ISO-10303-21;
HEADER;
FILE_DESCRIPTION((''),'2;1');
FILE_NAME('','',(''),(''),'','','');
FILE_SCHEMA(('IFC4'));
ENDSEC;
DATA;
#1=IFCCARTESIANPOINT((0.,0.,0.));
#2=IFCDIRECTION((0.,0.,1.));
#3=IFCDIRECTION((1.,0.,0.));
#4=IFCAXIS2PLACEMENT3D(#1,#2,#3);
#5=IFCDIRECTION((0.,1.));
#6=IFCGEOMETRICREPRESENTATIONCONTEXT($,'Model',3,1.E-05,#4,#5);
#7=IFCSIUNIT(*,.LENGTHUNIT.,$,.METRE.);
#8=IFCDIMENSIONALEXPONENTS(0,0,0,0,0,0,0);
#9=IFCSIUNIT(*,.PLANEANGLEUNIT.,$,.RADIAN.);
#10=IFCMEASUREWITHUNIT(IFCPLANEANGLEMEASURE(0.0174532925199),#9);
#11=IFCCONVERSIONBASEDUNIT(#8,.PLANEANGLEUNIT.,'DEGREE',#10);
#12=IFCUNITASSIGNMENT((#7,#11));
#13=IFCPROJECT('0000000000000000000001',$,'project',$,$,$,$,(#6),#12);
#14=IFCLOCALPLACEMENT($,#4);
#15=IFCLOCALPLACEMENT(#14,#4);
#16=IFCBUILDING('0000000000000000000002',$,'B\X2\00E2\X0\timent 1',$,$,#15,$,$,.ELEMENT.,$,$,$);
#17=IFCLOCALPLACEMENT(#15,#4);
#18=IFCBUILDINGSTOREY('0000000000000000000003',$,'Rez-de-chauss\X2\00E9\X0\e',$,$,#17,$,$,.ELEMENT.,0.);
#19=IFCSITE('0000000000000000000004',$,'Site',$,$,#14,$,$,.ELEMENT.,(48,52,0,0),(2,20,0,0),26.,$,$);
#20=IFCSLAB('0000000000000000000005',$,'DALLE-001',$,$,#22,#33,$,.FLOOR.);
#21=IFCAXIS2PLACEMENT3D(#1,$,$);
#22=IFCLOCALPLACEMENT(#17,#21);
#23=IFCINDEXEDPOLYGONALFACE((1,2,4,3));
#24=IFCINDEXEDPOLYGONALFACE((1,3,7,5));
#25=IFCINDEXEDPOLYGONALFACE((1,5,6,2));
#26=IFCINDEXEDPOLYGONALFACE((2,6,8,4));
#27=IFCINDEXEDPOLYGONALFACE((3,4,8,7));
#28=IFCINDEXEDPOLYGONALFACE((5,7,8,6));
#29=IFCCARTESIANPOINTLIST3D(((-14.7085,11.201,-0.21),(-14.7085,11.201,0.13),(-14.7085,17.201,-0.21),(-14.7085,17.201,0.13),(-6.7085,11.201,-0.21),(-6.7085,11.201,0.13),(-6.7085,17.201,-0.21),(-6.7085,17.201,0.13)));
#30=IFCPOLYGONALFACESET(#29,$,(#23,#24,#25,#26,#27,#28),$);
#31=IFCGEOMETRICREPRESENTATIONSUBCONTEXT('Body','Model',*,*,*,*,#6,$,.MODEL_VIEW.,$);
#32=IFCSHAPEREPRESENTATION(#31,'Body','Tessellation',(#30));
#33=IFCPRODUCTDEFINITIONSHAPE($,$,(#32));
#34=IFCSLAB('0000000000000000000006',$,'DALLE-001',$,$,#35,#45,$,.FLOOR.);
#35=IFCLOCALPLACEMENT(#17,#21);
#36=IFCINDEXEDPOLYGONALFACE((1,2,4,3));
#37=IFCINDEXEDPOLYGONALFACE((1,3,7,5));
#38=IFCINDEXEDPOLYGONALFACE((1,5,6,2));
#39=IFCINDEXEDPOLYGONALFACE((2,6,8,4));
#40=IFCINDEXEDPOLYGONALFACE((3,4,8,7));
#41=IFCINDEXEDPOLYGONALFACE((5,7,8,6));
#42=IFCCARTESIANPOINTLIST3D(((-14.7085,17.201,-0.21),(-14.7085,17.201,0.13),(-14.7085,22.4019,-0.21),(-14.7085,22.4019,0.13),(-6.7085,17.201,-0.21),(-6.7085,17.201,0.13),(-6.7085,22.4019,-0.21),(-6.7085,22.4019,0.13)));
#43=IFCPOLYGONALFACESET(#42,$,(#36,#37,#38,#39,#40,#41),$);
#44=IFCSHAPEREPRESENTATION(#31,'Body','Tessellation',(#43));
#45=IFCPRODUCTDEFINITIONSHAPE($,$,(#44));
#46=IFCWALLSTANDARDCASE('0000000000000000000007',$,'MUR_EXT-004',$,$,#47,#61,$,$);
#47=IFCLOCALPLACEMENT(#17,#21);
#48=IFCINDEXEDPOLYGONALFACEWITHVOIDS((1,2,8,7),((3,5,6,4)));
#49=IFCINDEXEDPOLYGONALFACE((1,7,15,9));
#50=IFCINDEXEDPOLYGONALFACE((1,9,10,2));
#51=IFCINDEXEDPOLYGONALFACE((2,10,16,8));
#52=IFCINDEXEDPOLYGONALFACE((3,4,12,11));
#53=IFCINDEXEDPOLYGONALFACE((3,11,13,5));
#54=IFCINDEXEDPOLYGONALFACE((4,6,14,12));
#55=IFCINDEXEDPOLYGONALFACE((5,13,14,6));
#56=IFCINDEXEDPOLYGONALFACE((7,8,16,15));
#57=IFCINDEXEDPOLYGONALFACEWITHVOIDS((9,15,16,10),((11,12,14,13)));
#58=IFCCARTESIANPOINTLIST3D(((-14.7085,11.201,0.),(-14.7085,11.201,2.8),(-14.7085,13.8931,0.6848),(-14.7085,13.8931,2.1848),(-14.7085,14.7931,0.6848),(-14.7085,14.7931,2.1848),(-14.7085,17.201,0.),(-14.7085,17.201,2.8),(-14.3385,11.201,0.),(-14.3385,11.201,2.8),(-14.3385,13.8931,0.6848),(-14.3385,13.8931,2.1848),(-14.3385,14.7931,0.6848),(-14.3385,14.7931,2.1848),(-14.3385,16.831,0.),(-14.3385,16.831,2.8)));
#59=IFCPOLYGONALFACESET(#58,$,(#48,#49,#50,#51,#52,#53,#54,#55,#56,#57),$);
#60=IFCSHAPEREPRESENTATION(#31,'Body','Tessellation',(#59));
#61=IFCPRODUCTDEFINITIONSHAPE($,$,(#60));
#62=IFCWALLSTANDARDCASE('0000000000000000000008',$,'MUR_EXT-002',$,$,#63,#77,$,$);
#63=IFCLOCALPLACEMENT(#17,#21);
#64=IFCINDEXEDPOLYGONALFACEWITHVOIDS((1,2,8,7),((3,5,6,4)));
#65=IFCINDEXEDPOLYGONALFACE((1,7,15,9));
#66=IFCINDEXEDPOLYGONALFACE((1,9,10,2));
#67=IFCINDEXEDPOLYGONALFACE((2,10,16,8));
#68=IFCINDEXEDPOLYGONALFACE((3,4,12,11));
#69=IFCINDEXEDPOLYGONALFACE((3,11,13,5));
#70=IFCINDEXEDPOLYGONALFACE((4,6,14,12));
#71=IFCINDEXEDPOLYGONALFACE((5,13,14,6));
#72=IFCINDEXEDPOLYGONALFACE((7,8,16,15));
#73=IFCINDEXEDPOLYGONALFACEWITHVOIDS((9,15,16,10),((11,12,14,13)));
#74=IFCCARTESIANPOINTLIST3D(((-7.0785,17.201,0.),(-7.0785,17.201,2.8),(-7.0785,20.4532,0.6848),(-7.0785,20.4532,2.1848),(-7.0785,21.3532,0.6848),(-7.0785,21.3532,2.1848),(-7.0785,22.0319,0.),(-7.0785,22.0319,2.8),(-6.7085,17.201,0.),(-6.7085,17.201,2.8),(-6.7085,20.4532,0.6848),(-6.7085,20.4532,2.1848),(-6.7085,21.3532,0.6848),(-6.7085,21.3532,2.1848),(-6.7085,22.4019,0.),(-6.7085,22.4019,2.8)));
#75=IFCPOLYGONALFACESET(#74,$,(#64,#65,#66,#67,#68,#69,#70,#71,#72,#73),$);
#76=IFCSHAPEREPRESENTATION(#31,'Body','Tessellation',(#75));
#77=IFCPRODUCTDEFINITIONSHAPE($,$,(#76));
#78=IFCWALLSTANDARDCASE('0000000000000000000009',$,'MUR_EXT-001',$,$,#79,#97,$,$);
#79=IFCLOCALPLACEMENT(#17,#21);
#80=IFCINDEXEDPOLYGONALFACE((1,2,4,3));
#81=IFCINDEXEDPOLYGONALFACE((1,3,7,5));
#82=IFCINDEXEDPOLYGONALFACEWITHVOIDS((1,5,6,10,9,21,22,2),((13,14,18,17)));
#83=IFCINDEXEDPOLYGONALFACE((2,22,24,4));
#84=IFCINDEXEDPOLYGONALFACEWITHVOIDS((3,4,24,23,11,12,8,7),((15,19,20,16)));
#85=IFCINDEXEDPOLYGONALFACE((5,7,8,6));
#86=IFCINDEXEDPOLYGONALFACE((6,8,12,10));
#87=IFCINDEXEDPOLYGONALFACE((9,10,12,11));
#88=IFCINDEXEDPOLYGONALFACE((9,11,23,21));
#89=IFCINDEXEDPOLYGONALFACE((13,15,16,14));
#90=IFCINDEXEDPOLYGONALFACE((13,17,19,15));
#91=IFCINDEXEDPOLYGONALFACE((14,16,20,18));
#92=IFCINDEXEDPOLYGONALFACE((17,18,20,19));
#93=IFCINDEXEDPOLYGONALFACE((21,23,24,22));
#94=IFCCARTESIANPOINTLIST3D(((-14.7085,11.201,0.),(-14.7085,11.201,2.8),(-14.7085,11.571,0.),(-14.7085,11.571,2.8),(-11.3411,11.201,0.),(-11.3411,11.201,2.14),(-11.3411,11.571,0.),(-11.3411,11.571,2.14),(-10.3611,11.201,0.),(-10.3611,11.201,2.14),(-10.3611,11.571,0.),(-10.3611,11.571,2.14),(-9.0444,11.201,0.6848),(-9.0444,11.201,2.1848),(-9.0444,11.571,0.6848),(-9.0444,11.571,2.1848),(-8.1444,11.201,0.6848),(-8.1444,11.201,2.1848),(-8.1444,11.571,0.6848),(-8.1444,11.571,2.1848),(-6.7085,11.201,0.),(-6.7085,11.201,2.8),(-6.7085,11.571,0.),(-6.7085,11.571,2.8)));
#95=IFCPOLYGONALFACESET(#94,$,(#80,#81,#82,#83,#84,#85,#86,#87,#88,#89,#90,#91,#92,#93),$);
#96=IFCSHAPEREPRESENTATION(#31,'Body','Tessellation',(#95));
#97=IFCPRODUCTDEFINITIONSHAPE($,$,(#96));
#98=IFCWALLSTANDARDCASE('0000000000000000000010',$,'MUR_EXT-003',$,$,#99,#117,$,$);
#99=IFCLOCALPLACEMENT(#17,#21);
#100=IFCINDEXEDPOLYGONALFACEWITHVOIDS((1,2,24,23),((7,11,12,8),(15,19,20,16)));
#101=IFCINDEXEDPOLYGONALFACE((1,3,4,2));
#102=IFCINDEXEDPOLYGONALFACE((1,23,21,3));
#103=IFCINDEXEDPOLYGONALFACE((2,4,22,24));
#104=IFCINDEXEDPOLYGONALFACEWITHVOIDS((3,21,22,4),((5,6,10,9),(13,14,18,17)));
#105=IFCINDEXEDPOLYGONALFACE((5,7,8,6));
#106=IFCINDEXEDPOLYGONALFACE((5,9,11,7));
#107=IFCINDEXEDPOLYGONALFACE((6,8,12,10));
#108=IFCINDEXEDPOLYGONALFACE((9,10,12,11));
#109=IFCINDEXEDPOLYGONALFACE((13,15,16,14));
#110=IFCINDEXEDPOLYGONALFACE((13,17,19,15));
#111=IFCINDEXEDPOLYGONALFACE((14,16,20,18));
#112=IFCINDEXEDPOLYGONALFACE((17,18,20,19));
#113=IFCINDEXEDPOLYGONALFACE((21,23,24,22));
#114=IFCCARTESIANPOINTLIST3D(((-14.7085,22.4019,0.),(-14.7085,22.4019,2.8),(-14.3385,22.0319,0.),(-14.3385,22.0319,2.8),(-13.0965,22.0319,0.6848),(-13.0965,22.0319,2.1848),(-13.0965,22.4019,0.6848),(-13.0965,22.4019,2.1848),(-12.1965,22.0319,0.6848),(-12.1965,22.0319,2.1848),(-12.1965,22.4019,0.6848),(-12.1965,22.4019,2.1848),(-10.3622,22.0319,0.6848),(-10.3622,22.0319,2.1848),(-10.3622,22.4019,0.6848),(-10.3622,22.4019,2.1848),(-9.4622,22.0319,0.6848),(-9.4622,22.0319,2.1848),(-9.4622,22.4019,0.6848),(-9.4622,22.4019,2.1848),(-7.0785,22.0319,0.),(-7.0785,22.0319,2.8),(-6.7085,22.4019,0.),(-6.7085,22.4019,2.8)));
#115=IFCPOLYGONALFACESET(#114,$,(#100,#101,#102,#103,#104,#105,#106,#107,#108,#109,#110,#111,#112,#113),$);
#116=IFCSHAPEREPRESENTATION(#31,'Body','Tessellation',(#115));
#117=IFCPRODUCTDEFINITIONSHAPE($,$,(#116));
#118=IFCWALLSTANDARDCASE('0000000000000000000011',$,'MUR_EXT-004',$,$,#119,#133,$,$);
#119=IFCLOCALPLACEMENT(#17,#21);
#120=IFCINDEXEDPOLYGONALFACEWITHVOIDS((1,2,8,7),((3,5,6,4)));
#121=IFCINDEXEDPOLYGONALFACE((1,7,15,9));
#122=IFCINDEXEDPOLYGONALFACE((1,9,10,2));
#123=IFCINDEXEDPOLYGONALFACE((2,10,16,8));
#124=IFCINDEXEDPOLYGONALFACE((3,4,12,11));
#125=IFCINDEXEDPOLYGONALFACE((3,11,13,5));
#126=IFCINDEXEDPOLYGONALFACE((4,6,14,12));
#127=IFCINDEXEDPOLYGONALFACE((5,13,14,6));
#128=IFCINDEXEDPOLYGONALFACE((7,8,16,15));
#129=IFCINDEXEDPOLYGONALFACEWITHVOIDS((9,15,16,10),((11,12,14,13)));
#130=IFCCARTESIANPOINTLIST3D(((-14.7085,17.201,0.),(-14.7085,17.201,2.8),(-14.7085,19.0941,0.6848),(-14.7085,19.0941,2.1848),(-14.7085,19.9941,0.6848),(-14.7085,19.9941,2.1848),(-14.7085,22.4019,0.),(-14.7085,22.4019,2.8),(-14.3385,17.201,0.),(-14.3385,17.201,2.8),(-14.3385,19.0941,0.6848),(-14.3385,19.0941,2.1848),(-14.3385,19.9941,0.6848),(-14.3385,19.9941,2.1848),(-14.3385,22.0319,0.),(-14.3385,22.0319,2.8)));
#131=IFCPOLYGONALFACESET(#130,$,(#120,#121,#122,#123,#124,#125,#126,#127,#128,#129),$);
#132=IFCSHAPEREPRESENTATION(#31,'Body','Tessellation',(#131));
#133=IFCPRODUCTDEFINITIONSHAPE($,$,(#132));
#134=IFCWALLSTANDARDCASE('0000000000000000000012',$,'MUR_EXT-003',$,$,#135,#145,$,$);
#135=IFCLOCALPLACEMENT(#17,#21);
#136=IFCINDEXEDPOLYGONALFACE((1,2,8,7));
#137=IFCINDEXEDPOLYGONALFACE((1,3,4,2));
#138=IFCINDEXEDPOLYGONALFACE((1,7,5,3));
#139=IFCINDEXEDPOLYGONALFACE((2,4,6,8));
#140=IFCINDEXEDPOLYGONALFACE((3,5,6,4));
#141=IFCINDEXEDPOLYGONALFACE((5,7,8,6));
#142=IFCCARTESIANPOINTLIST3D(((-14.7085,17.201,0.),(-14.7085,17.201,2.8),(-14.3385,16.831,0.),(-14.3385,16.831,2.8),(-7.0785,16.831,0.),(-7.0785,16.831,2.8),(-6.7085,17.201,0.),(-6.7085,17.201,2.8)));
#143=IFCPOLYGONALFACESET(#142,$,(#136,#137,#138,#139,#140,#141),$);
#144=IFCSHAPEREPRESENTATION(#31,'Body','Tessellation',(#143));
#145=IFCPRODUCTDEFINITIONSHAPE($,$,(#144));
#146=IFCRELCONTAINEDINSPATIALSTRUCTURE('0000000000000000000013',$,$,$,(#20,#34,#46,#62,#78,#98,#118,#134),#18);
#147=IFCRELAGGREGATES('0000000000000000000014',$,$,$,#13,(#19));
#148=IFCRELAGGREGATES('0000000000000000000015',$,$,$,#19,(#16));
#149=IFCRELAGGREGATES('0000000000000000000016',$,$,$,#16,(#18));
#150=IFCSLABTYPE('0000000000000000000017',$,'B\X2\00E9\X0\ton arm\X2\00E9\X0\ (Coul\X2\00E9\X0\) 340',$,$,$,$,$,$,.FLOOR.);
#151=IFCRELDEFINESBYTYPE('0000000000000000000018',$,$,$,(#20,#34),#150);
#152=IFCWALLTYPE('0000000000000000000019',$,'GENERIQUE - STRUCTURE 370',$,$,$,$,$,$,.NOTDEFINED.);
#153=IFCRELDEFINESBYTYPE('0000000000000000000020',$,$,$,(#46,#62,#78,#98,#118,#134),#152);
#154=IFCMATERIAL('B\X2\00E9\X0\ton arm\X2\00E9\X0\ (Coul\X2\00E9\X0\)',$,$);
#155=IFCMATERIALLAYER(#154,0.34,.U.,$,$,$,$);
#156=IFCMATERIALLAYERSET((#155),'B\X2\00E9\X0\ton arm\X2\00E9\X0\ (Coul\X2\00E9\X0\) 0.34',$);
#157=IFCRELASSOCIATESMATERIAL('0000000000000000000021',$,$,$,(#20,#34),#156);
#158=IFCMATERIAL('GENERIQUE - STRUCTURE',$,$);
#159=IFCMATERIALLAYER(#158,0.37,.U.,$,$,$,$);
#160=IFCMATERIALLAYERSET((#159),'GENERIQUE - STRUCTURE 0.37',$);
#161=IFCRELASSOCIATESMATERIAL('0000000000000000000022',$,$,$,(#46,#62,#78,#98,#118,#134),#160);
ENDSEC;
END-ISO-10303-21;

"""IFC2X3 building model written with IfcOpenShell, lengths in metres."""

from ifc_helpers import new_model, entity, si_unit, converted_unit, direction, frame, origin_with_axes, origin_2d_with_axis, place, context, subcontext, project, spatial, polyline, rectangle, outline, extrude, material, layer, layer_set, layer_usage, type_object, element, save


model = new_model("IFC2X3")

# Units and contexts
model_context = context("Model", 3, precision=1e-05, world=origin_with_axes(), true_north=direction((0.0, 1.0)))
body_context = subcontext(model_context, "Body", "Model", "MODEL_VIEW")
ifc_project = project(units=[si_unit("LENGTHUNIT", "METRE"), converted_unit("PLANEANGLEUNIT", "DEGREE", entity("IfcPlaneAngleMeasure", 0.0174532925199), si_unit("PLANEANGLEUNIT", "RADIAN"), dimensions=[0, 0, 0, 0, 0, 0, 0])], contexts=[model_context])

# Site, building, storey
site_placement = place(None, origin_with_axes())
site = spatial("IfcSite", under=ifc_project, at=site_placement, Name="Site", CompositionType="ELEMENT", RefLatitude=(48, 52, 0, 0), RefLongitude=(2, 20, 0, 0), RefElevation=26.0)
building_placement = place(site_placement, origin_with_axes())
building = spatial("IfcBuilding", under=site, at=building_placement, Name="Bâtiment 1", CompositionType="ELEMENT")
storey_placement = place(building_placement, origin_with_axes())
storey = spatial("IfcBuildingStorey", under=building, at=storey_placement, Name="Rez-de-chaussée", CompositionType="ELEMENT", Elevation=0.0)

# Slabs
ifc_material_1 = material(Name="Béton armé (Coulé)")
ifc_layer_1 = layer(ifc_material_1, 0.34, ventilated="UNKNOWN")
ifc_layer_set_1 = layer_set([ifc_layer_1], Name="Béton armé (Coulé) 0.34")
ifc_layer_usage_1 = layer_usage(ifc_layer_set_1, "AXIS3", "NEGATIVE", 0.34)
slab_type_1 = type_object("IfcSlabType", Name="Béton armé (Coulé) 340", PredefinedType="FLOOR")
slab_1_placement = place(storey_placement, frame((-14.7085, 11.201, 0.13), z_axis=(0.0, 0.0, 1.0), x_axis=(1.0, 0.0, 0.0)))
element("IfcSlab", 1, at=slab_1_placement, inside=storey, type_object=slab_type_1, material=ifc_layer_usage_1, Name="DALLE-001", PredefinedType="FLOOR", context=body_context, shape_type="SweptSolid", body=[
    extrude(outline(polyline([(0.0, 0.0), (8.0, 0.0), (8.0, 6.0), (0.0, 6.0), (0.0, 0.0)])), frame((0.0, 0.0, -0.34), z_axis=(0.0, 0.0, 1.0), x_axis=(1.0, 0.0, 0.0)), (0.0, 0.0, 1.0), 0.34),
])
ifc_layer_usage_2 = layer_usage(ifc_layer_set_1, "AXIS3", "NEGATIVE", 0.34)
slab_2_placement = place(storey_placement, frame((-14.7085, 17.201, 0.13), z_axis=(0.0, 0.0, 1.0), x_axis=(1.0, 0.0, 0.0)))
element("IfcSlab", 2, at=slab_2_placement, inside=storey, type_object=slab_type_1, material=ifc_layer_usage_2, Name="DALLE-001", PredefinedType="FLOOR", context=body_context, shape_type="SweptSolid", body=[
    extrude(outline(polyline([(0.0, 0.0), (8.0, 0.0), (8.0, 5.201), (0.0, 5.201), (0.0, 0.0)])), frame((0.0, 0.0, -0.34), z_axis=(0.0, 0.0, 1.0), x_axis=(1.0, 0.0, 0.0)), (0.0, 0.0, 1.0), 0.34),
])

# Walls, openings
ifc_material_2 = material(Name="GENERIQUE - STRUCTURE")
ifc_layer_2 = layer(ifc_material_2, 0.37, ventilated="UNKNOWN")
ifc_layer_set_2 = layer_set([ifc_layer_2], Name="GENERIQUE - STRUCTURE 0.37")
ifc_layer_usage_3 = layer_usage(ifc_layer_set_2, "AXIS2", "POSITIVE", 0.0)
wall_type_1 = type_object("IfcWallType", Name="GENERIQUE - STRUCTURE 370", PredefinedType="NOTDEFINED")
wall_1_placement = place(storey_placement, frame((-14.7085, 17.201, 0.0), z_axis=(0.0, 0.0, 1.0), x_axis=(0.0, -1.0, 0.0)))
wall_1 = element("IfcWallStandardCase", 3, at=wall_1_placement, inside=storey, type_object=wall_type_1, material=ifc_layer_usage_3, Name="MUR_EXT-004", context=body_context, shape_type="SweptSolid", body=[
    extrude(outline(polyline([(0.0, 0.0), (6.0, 0.0), (6.0, 0.37), (0.37, 0.37), (0.0, 0.0)])), origin_with_axes(), (0.0, 0.0, 1.0), 2.8),
])
opening_1_placement = place(wall_1_placement, frame((2.8579, 0.0, 0.6848), z_axis=(0.0, 0.0, 1.0), x_axis=(1.0, 0.0, 0.0)))
element("IfcOpeningElement", 4, at=opening_1_placement, cuts=wall_1, context=body_context, shape_type="SweptSolid", body=[
    extrude(rectangle(XDim=0.9, YDim=1.5, at=origin_2d_with_axis()), frame((0.0, 0.37, 0.75), z_axis=(0.0, -1.0, 0.0), x_axis=(-1.0, 0.0, 0.0)), (0.0, 0.0, 1.0), 1.11),
])
ifc_layer_usage_4 = layer_usage(ifc_layer_set_2, "AXIS2", "POSITIVE", 0.0)
wall_2_placement = place(storey_placement, frame((-6.7085, 17.201, 0.0), z_axis=(0.0, 0.0, 1.0), x_axis=(0.0, 1.0, 0.0)))
wall_2 = element("IfcWallStandardCase", 5, at=wall_2_placement, inside=storey, type_object=wall_type_1, material=ifc_layer_usage_4, Name="MUR_EXT-002", context=body_context, shape_type="SweptSolid", body=[
    extrude(outline(polyline([(0.0, 0.0), (5.201, 0.0), (4.831, 0.37), (0.0, 0.37), (0.0, 0.0)])), origin_with_axes(), (0.0, 0.0, 1.0), 2.8),
])
opening_2_placement = place(wall_2_placement, frame((3.7022, 0.0, 0.6848), z_axis=(0.0, 0.0, 1.0), x_axis=(1.0, 0.0, 0.0)))
element("IfcOpeningElement", 6, at=opening_2_placement, cuts=wall_2, context=body_context, shape_type="SweptSolid", body=[
    extrude(rectangle(XDim=0.9, YDim=1.5, at=origin_2d_with_axis()), frame((0.0, 0.37, 0.75), z_axis=(0.0, -1.0, 0.0), x_axis=(-1.0, 0.0, 0.0)), (0.0, 0.0, 1.0), 1.11),
])

# Walls, openings
ifc_layer_usage_5 = layer_usage(ifc_layer_set_2, "AXIS2", "POSITIVE", 0.0)
wall_3_placement = place(storey_placement, frame((-14.7085, 11.201, 0.0), z_axis=(0.0, 0.0, 1.0), x_axis=(1.0, 0.0, 0.0)))
wall_3 = element("IfcWallStandardCase", 7, at=wall_3_placement, inside=storey, type_object=wall_type_1, material=ifc_layer_usage_5, Name="MUR_EXT-001", context=body_context, shape_type="SweptSolid", body=[
    extrude(outline(polyline([(0.0, 0.0), (8.0, 0.0), (8.0, 0.37), (0.0, 0.37), (0.0, 0.0)])), origin_with_axes(), (0.0, 0.0, 1.0), 2.8),
])
opening_3_placement = place(wall_3_placement, frame((6.1141, 0.0, 0.6848), z_axis=(0.0, 0.0, 1.0), x_axis=(1.0, 0.0, 0.0)))
element("IfcOpeningElement", 8, at=opening_3_placement, cuts=wall_3, context=body_context, shape_type="SweptSolid", body=[
    extrude(rectangle(XDim=0.9, YDim=1.5, at=origin_2d_with_axis()), frame((0.0, 0.37, 0.75), z_axis=(0.0, 1.0, 0.0), x_axis=(1.0, 0.0, 0.0)), (0.0, 0.0, -1.0), 1.11),
])
opening_4_placement = place(wall_3_placement, frame((3.8574, 0.0, 0.0), z_axis=(0.0, 0.0, 1.0), x_axis=(1.0, 0.0, 0.0)))
element("IfcOpeningElement", 9, at=opening_4_placement, cuts=wall_3, context=body_context, shape_type="SweptSolid", body=[
    extrude(rectangle(XDim=0.98, YDim=2.14, at=origin_2d_with_axis()), frame((0.0, 0.37, 1.07), z_axis=(0.0, 1.0, 0.0), x_axis=(1.0, 0.0, 0.0)), (0.0, 0.0, -1.0), 1.11),
])
ifc_layer_usage_6 = layer_usage(ifc_layer_set_2, "AXIS2", "POSITIVE", 0.0)
wall_4_placement = place(storey_placement, frame((-6.7085, 22.4019, 0.0), z_axis=(0.0, 0.0, 1.0), x_axis=(-1.0, 0.0, 0.0)))
wall_4 = element("IfcWallStandardCase", 10, at=wall_4_placement, inside=storey, type_object=wall_type_1, material=ifc_layer_usage_6, Name="MUR_EXT-003", context=body_context, shape_type="SweptSolid", body=[
    extrude(outline(polyline([(0.0, 0.0), (8.0, 0.0), (7.63, 0.37), (0.37, 0.37), (0.0, 0.0)])), origin_with_axes(), (0.0, 0.0, 1.0), 2.8),
])
opening_5_placement = place(wall_4_placement, frame((3.2036, 0.0, 0.6848), z_axis=(0.0, 0.0, 1.0), x_axis=(1.0, 0.0, 0.0)))
element("IfcOpeningElement", 11, at=opening_5_placement, cuts=wall_4, context=body_context, shape_type="SweptSolid", body=[
    extrude(rectangle(XDim=0.9, YDim=1.5, at=origin_2d_with_axis()), frame((0.0, 0.37, 0.75), z_axis=(0.0, -1.0, 0.0), x_axis=(-1.0, 0.0, 0.0)), (0.0, 0.0, 1.0), 1.11),
])
opening_6_placement = place(wall_4_placement, frame((5.938, 0.0, 0.6848), z_axis=(0.0, 0.0, 1.0), x_axis=(1.0, 0.0, 0.0)))
element("IfcOpeningElement", 12, at=opening_6_placement, cuts=wall_4, context=body_context, shape_type="SweptSolid", body=[
    extrude(rectangle(XDim=0.9, YDim=1.5, at=origin_2d_with_axis()), frame((0.0, 0.37, 0.75), z_axis=(0.0, 1.0, 0.0), x_axis=(1.0, 0.0, 0.0)), (0.0, 0.0, -1.0), 1.11),
])

# Wall, opening
ifc_layer_usage_7 = layer_usage(ifc_layer_set_2, "AXIS2", "POSITIVE", 0.0)
wall_5_placement = place(storey_placement, frame((-14.7085, 22.4019, 0.0), z_axis=(0.0, 0.0, 1.0), x_axis=(0.0, -1.0, 0.0)))
wall_5 = element("IfcWallStandardCase", 13, at=wall_5_placement, inside=storey, type_object=wall_type_1, material=ifc_layer_usage_7, Name="MUR_EXT-004", context=body_context, shape_type="SweptSolid", body=[
    extrude(outline(polyline([(0.0, 0.0), (5.201, 0.0), (5.201, 0.37), (0.37, 0.37), (0.0, 0.0)])), origin_with_axes(), (0.0, 0.0, 1.0), 2.8),
])
opening_7_placement = place(wall_5_placement, frame((2.8579, 0.0, 0.6848), z_axis=(0.0, 0.0, 1.0), x_axis=(1.0, 0.0, 0.0)))
element("IfcOpeningElement", 14, at=opening_7_placement, cuts=wall_5, context=body_context, shape_type="SweptSolid", body=[
    extrude(rectangle(XDim=0.9, YDim=1.5, at=origin_2d_with_axis()), frame((0.0, 0.37, 0.75), z_axis=(0.0, -1.0, 0.0), x_axis=(-1.0, 0.0, 0.0)), (0.0, 0.0, 1.0), 1.11),
])

# Wall
ifc_layer_usage_8 = layer_usage(ifc_layer_set_2, "AXIS2", "POSITIVE", 0.0)
wall_6_placement = place(storey_placement, frame((-6.7085, 17.201, 0.0), z_axis=(0.0, 0.0, 1.0), x_axis=(-1.0, 0.0, 0.0)))
element("IfcWallStandardCase", 15, at=wall_6_placement, inside=storey, type_object=wall_type_1, material=ifc_layer_usage_8, Name="MUR_EXT-003", context=body_context, shape_type="SweptSolid", body=[
    extrude(outline(polyline([(0.0, 0.0), (8.0, 0.0), (7.63, 0.37), (0.37, 0.37), (0.0, 0.0)])), origin_with_axes(), (0.0, 0.0, 1.0), 2.8),
])

save(model, "model.ifc")
